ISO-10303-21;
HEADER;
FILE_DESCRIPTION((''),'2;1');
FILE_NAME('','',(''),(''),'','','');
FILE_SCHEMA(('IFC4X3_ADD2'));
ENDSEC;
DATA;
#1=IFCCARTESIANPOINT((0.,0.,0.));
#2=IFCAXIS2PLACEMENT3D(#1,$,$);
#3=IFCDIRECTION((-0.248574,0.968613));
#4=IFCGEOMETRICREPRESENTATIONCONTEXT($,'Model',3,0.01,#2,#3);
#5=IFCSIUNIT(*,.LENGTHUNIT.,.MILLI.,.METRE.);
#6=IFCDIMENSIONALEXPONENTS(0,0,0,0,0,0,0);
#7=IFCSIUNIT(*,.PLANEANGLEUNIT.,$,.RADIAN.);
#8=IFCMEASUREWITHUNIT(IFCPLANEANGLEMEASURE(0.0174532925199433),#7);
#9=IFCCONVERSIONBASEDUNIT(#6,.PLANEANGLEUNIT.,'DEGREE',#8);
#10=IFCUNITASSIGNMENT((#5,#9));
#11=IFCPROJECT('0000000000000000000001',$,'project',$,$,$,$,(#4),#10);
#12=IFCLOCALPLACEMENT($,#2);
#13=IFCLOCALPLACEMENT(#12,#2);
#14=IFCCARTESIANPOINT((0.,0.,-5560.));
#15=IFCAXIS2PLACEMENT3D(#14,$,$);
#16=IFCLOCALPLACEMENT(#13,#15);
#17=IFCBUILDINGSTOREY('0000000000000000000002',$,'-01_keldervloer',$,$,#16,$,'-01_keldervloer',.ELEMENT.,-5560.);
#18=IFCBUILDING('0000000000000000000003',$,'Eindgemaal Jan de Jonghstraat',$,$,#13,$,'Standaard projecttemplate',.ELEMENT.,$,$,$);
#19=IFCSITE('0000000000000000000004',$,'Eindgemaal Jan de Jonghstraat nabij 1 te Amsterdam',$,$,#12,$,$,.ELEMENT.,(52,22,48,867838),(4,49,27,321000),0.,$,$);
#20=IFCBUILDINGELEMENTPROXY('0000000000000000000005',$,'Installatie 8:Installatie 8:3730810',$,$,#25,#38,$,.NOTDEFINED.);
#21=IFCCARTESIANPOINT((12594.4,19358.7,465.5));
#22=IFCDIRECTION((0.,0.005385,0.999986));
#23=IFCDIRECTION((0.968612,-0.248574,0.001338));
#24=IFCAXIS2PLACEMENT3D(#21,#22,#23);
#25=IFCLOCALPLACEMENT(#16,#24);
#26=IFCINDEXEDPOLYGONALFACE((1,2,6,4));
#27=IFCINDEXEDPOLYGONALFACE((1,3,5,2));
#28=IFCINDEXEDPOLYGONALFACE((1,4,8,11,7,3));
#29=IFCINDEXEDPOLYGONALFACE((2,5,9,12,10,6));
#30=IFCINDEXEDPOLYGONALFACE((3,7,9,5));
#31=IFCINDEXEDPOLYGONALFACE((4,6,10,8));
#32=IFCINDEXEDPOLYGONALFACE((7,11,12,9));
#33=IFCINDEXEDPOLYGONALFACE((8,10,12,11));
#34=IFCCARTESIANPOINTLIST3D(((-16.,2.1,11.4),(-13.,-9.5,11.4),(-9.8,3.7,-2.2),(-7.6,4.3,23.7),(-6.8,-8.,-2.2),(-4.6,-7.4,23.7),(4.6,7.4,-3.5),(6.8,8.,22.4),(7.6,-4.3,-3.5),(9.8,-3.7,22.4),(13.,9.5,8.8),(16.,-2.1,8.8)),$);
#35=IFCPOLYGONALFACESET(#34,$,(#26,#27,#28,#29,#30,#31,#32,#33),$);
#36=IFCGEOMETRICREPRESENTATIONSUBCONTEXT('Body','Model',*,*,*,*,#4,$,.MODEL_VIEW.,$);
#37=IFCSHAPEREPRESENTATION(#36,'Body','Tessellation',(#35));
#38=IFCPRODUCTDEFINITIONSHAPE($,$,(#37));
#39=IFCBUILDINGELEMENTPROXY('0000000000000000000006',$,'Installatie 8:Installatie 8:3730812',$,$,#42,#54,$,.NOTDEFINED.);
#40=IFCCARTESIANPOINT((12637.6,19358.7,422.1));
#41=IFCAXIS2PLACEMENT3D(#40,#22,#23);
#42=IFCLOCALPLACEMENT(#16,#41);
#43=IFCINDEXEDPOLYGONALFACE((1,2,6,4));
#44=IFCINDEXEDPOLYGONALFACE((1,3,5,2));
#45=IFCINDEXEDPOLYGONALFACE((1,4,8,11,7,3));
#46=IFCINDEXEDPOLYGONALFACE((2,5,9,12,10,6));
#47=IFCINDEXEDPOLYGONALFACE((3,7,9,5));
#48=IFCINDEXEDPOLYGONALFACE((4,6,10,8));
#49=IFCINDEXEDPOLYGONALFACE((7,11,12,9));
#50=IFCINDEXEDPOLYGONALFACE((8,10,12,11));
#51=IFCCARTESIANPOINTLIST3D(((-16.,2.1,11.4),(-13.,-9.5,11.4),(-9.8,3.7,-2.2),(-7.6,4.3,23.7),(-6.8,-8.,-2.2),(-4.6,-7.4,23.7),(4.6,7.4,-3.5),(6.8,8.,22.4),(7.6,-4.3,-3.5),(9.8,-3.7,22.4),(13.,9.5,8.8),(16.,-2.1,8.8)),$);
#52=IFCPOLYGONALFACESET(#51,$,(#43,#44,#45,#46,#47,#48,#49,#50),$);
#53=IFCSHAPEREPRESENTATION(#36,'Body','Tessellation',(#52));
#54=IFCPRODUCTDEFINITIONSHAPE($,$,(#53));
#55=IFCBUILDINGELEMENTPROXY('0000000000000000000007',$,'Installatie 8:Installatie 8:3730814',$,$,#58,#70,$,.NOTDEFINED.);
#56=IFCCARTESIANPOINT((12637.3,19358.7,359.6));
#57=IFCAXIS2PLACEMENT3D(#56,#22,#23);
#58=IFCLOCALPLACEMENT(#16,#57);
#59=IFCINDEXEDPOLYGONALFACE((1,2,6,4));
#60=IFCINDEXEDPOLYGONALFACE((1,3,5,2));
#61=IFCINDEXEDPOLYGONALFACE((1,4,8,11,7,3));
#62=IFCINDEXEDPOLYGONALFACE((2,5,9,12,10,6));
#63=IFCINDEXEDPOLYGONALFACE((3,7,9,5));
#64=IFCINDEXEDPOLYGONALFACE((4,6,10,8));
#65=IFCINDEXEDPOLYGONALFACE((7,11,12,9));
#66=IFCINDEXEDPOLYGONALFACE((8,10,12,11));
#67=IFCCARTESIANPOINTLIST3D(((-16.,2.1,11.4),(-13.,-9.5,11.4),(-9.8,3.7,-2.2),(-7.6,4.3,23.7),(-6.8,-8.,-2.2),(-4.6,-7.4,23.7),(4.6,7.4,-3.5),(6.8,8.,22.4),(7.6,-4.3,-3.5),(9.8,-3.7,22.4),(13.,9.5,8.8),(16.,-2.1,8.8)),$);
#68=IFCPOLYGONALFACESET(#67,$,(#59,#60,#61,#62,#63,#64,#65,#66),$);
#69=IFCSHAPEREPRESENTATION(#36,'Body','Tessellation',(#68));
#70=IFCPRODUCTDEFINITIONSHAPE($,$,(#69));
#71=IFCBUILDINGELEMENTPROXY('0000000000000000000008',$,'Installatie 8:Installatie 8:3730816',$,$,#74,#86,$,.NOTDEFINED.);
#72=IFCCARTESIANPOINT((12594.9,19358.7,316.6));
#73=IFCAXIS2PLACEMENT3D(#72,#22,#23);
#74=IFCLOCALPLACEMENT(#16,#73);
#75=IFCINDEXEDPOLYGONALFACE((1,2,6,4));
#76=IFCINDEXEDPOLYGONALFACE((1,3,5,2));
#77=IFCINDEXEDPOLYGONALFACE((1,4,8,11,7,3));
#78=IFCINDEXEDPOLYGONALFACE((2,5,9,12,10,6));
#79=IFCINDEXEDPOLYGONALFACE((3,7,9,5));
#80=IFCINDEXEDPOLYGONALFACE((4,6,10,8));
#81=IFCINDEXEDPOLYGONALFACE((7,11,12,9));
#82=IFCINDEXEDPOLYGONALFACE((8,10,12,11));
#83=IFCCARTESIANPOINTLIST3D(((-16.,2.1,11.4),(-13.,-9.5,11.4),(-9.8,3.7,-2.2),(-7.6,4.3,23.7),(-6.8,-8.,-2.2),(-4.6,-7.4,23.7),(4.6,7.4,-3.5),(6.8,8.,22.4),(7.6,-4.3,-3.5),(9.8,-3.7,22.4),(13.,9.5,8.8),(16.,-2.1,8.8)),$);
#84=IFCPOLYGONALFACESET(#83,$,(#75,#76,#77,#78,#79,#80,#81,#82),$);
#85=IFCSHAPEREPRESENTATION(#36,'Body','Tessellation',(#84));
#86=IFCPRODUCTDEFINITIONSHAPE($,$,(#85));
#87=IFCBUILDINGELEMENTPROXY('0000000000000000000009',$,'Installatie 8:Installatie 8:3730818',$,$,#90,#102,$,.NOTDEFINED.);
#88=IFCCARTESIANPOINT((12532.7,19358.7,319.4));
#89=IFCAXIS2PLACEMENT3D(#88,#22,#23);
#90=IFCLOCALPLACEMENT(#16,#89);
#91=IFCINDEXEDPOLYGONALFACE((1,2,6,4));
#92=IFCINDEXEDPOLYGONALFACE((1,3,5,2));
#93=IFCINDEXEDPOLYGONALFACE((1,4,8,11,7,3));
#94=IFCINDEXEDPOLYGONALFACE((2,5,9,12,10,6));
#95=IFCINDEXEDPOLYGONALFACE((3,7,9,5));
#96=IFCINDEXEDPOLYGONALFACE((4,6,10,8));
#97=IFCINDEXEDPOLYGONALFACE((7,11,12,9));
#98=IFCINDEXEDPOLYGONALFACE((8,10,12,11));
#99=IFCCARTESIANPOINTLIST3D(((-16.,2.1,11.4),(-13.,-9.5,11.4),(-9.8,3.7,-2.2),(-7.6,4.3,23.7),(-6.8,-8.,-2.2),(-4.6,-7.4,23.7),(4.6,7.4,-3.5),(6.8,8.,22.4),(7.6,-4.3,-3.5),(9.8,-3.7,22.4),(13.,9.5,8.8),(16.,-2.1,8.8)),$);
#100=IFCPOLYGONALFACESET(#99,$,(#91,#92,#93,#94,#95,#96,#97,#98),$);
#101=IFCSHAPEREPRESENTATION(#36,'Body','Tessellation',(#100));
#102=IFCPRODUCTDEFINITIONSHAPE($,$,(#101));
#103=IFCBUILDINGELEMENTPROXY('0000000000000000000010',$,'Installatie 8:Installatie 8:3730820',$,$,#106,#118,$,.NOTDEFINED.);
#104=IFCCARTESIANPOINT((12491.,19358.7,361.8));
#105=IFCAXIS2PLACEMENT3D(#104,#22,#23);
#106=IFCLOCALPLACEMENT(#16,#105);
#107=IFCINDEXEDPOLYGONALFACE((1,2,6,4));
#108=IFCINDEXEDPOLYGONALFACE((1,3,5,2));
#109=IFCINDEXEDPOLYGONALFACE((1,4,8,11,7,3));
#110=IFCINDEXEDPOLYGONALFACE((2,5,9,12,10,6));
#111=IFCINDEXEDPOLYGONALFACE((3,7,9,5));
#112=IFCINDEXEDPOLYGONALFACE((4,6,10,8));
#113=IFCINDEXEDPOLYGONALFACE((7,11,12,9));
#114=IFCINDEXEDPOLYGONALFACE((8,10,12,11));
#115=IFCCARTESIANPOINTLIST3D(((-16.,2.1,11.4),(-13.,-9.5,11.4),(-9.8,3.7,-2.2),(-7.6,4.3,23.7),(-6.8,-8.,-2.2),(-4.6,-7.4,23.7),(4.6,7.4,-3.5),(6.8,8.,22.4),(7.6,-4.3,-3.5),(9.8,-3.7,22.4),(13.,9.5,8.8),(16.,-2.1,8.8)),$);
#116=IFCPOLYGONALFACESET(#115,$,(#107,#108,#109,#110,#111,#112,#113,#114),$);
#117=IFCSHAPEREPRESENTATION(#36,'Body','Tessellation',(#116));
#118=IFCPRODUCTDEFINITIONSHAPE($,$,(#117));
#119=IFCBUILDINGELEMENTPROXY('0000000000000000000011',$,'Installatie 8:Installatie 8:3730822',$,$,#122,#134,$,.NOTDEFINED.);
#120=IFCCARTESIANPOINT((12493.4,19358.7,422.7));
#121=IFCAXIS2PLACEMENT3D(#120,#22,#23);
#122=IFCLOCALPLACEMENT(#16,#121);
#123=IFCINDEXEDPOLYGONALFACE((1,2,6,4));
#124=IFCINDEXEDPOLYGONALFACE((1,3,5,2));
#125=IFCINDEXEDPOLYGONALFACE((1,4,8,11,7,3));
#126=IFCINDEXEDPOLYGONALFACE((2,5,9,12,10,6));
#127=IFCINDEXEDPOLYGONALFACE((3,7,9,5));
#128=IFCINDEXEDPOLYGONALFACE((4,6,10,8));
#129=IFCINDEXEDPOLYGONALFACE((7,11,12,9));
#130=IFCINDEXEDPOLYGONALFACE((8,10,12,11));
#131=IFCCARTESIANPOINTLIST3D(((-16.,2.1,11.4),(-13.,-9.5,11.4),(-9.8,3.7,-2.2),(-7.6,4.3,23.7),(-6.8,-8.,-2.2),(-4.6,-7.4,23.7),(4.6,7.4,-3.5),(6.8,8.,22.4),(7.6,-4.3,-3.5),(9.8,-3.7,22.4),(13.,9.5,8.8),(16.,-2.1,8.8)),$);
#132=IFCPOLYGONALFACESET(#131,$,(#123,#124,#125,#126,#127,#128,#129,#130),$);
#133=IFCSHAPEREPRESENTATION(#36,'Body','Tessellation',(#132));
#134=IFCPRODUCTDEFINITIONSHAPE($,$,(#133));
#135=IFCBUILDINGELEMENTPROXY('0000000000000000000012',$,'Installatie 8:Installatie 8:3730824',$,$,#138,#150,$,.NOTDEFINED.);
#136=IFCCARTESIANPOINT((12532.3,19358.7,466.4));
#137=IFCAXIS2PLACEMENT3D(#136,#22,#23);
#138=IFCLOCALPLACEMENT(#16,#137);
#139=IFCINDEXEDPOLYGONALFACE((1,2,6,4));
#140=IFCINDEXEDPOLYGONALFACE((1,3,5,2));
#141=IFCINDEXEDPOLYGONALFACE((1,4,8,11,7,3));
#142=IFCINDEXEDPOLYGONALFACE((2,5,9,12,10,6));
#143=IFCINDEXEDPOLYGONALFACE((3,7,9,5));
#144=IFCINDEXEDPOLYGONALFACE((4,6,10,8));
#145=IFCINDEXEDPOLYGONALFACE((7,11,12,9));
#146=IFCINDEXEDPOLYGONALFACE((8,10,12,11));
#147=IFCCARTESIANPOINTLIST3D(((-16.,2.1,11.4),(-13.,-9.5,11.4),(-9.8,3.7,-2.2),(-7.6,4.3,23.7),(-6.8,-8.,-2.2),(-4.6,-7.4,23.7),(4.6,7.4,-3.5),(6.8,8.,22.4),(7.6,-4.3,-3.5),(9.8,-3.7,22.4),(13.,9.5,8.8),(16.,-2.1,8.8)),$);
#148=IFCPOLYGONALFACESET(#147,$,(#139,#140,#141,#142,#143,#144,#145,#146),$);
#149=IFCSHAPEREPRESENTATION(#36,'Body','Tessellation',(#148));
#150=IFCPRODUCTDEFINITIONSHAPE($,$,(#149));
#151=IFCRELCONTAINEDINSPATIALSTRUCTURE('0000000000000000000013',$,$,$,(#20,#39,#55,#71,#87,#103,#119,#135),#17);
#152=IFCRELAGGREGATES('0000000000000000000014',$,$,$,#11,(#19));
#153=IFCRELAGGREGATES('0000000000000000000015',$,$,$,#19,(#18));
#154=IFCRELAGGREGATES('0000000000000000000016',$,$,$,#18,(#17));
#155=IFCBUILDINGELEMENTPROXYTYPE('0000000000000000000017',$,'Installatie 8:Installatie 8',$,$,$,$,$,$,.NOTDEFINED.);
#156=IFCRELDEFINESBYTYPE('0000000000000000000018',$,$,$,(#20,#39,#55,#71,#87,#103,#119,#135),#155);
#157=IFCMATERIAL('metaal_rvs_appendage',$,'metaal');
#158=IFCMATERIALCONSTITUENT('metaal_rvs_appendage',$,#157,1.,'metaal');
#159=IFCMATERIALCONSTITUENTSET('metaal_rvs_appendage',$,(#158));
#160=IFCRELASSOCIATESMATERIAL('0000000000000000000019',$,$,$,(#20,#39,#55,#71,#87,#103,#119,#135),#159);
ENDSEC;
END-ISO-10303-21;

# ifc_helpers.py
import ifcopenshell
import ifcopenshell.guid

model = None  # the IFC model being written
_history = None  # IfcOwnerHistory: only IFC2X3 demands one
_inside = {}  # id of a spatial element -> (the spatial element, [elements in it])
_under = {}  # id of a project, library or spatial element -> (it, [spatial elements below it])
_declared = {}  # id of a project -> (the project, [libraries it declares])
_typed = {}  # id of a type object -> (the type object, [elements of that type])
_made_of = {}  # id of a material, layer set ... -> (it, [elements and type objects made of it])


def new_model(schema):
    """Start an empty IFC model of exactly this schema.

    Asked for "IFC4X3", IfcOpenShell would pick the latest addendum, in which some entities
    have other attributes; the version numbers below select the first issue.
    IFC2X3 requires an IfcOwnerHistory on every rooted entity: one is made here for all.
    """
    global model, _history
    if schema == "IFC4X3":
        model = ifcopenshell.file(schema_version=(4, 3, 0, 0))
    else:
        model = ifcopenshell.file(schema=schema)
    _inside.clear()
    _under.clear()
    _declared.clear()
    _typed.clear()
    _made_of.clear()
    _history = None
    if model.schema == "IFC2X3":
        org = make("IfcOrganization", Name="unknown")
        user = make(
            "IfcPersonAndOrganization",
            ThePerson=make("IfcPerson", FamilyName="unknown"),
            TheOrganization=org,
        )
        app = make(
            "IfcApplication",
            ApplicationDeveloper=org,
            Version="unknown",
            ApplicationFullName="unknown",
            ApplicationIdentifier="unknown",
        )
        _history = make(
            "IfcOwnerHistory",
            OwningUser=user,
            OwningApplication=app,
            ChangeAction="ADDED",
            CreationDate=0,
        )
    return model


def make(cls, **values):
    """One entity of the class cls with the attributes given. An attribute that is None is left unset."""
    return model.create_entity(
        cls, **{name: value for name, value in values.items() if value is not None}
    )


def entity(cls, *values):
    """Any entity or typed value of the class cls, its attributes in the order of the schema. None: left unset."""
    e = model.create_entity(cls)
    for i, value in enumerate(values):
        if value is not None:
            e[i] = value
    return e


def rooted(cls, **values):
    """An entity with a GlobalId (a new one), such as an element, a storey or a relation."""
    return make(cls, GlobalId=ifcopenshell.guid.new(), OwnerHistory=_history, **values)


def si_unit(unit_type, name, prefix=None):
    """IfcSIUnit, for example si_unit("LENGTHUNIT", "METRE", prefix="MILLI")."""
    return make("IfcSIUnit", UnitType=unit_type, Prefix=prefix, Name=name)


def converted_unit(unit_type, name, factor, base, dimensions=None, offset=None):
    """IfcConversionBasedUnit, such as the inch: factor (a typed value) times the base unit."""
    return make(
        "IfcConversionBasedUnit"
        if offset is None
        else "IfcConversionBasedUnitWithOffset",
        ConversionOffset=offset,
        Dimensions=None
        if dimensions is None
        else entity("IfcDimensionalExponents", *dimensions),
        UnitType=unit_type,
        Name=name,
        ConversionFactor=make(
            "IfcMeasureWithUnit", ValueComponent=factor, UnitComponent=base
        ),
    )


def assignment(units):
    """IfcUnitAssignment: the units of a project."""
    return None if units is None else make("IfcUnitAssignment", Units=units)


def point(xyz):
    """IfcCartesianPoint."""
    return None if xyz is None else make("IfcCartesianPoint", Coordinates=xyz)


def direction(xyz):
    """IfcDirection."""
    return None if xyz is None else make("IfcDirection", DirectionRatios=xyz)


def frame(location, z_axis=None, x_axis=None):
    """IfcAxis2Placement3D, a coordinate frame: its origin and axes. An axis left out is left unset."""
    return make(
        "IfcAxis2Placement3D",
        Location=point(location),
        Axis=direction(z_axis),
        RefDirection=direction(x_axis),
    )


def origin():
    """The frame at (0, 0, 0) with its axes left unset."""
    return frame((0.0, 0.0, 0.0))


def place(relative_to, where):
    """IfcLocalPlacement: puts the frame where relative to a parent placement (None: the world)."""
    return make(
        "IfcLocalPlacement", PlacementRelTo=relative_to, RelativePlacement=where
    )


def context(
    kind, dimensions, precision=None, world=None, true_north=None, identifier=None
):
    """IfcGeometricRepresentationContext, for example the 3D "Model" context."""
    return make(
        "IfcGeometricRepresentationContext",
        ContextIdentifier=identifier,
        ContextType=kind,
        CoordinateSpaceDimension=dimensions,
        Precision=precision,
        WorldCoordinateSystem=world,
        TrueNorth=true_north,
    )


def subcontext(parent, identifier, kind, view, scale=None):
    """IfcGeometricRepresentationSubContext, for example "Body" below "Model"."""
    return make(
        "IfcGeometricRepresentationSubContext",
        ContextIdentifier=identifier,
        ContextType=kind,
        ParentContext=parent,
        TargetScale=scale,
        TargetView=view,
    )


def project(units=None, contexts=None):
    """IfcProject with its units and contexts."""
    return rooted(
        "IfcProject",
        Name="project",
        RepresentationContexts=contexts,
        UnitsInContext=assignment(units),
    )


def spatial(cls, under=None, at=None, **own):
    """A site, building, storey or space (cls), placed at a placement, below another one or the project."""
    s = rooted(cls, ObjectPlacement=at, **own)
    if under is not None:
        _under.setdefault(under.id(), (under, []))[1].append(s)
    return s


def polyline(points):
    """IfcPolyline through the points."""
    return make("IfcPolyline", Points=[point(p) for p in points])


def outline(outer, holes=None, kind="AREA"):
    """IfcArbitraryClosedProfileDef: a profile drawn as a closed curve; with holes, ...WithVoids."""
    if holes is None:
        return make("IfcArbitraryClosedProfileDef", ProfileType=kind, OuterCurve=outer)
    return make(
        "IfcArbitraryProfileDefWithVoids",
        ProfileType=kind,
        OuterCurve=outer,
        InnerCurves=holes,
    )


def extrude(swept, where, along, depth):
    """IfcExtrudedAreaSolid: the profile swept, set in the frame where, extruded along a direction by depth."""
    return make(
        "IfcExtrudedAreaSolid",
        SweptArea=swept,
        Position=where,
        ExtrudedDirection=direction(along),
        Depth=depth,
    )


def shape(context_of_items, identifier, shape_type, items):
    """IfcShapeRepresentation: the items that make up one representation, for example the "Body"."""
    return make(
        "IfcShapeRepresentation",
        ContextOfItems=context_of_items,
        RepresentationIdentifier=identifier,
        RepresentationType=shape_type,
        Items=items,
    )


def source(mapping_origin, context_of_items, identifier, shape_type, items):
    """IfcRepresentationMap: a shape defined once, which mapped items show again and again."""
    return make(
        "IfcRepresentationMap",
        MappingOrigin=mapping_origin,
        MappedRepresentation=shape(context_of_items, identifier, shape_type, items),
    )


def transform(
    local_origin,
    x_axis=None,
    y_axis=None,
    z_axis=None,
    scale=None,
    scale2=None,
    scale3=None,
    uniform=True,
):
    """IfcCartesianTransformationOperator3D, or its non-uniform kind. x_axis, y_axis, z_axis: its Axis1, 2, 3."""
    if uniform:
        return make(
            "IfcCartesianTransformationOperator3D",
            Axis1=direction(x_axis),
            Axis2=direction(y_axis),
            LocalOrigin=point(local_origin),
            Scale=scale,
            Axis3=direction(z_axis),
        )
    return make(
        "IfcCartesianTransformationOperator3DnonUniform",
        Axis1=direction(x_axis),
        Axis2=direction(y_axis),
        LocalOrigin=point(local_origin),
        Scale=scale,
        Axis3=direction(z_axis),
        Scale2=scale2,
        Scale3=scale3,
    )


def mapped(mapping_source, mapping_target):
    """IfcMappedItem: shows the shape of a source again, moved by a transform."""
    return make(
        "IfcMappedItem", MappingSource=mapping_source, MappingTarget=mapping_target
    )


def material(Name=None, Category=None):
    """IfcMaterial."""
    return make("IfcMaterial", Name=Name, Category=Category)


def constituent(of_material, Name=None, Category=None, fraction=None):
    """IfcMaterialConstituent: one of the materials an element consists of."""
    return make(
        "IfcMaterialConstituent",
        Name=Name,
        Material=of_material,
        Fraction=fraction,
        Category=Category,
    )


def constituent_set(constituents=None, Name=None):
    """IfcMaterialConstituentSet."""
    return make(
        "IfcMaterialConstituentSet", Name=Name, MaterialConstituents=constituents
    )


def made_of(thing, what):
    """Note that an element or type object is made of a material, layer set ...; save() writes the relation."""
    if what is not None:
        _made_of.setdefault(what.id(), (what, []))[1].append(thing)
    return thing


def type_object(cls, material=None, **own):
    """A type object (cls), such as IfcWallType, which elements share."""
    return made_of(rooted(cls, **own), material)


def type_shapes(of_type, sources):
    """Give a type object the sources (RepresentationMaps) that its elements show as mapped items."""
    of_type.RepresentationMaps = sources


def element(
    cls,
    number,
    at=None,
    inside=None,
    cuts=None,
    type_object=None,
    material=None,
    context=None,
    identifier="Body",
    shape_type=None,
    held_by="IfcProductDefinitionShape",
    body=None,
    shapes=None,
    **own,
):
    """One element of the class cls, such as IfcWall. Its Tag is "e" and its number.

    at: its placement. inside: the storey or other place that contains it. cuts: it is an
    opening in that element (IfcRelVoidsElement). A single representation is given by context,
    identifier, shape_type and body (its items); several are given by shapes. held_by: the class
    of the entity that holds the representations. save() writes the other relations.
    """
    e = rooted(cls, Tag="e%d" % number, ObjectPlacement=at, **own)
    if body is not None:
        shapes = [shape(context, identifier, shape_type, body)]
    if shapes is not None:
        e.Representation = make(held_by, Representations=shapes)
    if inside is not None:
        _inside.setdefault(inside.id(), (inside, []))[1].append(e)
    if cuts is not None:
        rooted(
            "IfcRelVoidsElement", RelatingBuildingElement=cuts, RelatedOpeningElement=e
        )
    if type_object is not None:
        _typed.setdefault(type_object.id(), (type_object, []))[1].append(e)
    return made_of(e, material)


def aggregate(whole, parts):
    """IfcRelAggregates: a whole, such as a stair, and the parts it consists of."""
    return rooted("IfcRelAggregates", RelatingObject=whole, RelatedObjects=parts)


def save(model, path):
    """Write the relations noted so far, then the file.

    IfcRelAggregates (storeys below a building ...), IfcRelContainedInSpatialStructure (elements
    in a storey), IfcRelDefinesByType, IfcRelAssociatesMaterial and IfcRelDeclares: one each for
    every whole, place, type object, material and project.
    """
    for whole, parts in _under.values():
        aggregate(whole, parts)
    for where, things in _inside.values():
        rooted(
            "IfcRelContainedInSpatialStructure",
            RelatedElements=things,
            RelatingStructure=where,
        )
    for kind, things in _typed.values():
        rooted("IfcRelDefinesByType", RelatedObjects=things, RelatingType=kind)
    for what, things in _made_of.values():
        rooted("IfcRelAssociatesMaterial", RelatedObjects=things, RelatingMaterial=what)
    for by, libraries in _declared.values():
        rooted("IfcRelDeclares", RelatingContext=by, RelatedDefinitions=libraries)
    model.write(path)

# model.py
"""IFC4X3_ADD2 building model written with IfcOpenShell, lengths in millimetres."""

from ifc_helpers import new_model, entity, si_unit, converted_unit, direction, frame, origin, place, context, subcontext, project, spatial, polyline, outline, extrude, source, transform, mapped, material, constituent, constituent_set, type_object, type_shapes, element, save


model = new_model("IFC4X3_ADD2")

# Units and contexts
model_context = context("Model", 3, precision=0.01, world=origin(), true_north=direction((-0.248574, 0.968613)))
body_context = subcontext(model_context, "Body", "Model", "MODEL_VIEW")
ifc_project = project(units=[si_unit("LENGTHUNIT", "METRE", prefix="MILLI"), converted_unit("PLANEANGLEUNIT", "DEGREE", entity("IfcPlaneAngleMeasure", 0.0174532925199433), si_unit("PLANEANGLEUNIT", "RADIAN"), dimensions=[0, 0, 0, 0, 0, 0, 0])], contexts=[model_context])

# Site, building, storey
site_placement = place(None, origin())
site = spatial("IfcSite", under=ifc_project, at=site_placement, Name="Eindgemaal Jan de Jonghstraat nabij 1 te Amsterdam", CompositionType="ELEMENT", RefLatitude=(52, 22, 48, 867838), RefLongitude=(4, 49, 27, 321000), RefElevation=0.0)
building_placement = place(site_placement, origin())
building = spatial("IfcBuilding", under=site, at=building_placement, Name="Eindgemaal Jan de Jonghstraat", LongName="Standaard projecttemplate", CompositionType="ELEMENT")
storey_placement = place(building_placement, frame((0.0, 0.0, -5560.0)))
storey = spatial("IfcBuildingStorey", under=building, at=storey_placement, Name="-01_keldervloer", LongName="-01_keldervloer", CompositionType="ELEMENT", Elevation=-5560.0)

# Building element proxies
ifc_material_1 = material(Name="metaal_rvs_appendage", Category="metaal")
ifc_constituent_1 = constituent(ifc_material_1, Name="metaal_rvs_appendage", Category="metaal", fraction=1.0)
ifc_constituent_set_1 = constituent_set(constituents=[ifc_constituent_1], Name="metaal_rvs_appendage")
building_element_proxy_type_1 = type_object("IfcBuildingElementProxyType", Name="Installatie 8:Installatie 8", PredefinedType="NOTDEFINED")
shared_shape_1 = source(origin(), body_context, "Body", "SweptSolid", [
    extrude(outline(polyline([(-7.5, -13.0), (7.5, -13.0), (15.0, 0.0), (7.5, 13.0), (-7.5, 13.0), (-15.0, 0.0), (-7.5, -13.0)])), frame((1.5, -5.8, 10.1), z_axis=(-0.248574, 0.968613, 0.0), x_axis=(-0.555573, -0.142576, -0.819152)), (0.0, 0.0, 1.0), 12.0),
])
type_shapes(building_element_proxy_type_1, [shared_shape_1])
for number, where, z_axis, x_axis, name in (
    (1, (12594.4, 19358.7, 465.5), (0.0, 0.005385, 0.999986), (0.968612, -0.248574, 0.001338), "Installatie 8:Installatie 8:3730810"),
    (2, (12637.6, 19358.7, 422.1), (0.0, 0.005385, 0.999986), (0.968612, -0.248574, 0.001338), "Installatie 8:Installatie 8:3730812"),
    (3, (12637.3, 19358.7, 359.6), (0.0, 0.005385, 0.999986), (0.968612, -0.248574, 0.001338), "Installatie 8:Installatie 8:3730814"),
    (4, (12594.9, 19358.7, 316.6), (0.0, 0.005385, 0.999986), (0.968612, -0.248574, 0.001338), "Installatie 8:Installatie 8:3730816"),
    (5, (12532.7, 19358.7, 319.4), (0.0, 0.005385, 0.999986), (0.968612, -0.248574, 0.001338), "Installatie 8:Installatie 8:3730818"),
    (6, (12491.0, 19358.7, 361.8), (0.0, 0.005385, 0.999986), (0.968612, -0.248574, 0.001338), "Installatie 8:Installatie 8:3730820"),
    (7, (12493.4, 19358.7, 422.7), (0.0, 0.005385, 0.999986), (0.968612, -0.248574, 0.001338), "Installatie 8:Installatie 8:3730822"),
    (8, (12532.3, 19358.7, 466.4), (0.0, 0.005385, 0.999986), (0.968612, -0.248574, 0.001338), "Installatie 8:Installatie 8:3730824"),
):
    element("IfcBuildingElementProxy", number, at=place(storey_placement, frame(where, z_axis=z_axis, x_axis=x_axis)), inside=storey, type_object=building_element_proxy_type_1, material=ifc_constituent_set_1, Name=name, PredefinedType="NOTDEFINED", context=body_context, shape_type="MappedRepresentation", body=[
        mapped(shared_shape_1, transform((0.0, 0.0, 0.0), scale=1.0)),
    ])

save(model, "model.ifc")
